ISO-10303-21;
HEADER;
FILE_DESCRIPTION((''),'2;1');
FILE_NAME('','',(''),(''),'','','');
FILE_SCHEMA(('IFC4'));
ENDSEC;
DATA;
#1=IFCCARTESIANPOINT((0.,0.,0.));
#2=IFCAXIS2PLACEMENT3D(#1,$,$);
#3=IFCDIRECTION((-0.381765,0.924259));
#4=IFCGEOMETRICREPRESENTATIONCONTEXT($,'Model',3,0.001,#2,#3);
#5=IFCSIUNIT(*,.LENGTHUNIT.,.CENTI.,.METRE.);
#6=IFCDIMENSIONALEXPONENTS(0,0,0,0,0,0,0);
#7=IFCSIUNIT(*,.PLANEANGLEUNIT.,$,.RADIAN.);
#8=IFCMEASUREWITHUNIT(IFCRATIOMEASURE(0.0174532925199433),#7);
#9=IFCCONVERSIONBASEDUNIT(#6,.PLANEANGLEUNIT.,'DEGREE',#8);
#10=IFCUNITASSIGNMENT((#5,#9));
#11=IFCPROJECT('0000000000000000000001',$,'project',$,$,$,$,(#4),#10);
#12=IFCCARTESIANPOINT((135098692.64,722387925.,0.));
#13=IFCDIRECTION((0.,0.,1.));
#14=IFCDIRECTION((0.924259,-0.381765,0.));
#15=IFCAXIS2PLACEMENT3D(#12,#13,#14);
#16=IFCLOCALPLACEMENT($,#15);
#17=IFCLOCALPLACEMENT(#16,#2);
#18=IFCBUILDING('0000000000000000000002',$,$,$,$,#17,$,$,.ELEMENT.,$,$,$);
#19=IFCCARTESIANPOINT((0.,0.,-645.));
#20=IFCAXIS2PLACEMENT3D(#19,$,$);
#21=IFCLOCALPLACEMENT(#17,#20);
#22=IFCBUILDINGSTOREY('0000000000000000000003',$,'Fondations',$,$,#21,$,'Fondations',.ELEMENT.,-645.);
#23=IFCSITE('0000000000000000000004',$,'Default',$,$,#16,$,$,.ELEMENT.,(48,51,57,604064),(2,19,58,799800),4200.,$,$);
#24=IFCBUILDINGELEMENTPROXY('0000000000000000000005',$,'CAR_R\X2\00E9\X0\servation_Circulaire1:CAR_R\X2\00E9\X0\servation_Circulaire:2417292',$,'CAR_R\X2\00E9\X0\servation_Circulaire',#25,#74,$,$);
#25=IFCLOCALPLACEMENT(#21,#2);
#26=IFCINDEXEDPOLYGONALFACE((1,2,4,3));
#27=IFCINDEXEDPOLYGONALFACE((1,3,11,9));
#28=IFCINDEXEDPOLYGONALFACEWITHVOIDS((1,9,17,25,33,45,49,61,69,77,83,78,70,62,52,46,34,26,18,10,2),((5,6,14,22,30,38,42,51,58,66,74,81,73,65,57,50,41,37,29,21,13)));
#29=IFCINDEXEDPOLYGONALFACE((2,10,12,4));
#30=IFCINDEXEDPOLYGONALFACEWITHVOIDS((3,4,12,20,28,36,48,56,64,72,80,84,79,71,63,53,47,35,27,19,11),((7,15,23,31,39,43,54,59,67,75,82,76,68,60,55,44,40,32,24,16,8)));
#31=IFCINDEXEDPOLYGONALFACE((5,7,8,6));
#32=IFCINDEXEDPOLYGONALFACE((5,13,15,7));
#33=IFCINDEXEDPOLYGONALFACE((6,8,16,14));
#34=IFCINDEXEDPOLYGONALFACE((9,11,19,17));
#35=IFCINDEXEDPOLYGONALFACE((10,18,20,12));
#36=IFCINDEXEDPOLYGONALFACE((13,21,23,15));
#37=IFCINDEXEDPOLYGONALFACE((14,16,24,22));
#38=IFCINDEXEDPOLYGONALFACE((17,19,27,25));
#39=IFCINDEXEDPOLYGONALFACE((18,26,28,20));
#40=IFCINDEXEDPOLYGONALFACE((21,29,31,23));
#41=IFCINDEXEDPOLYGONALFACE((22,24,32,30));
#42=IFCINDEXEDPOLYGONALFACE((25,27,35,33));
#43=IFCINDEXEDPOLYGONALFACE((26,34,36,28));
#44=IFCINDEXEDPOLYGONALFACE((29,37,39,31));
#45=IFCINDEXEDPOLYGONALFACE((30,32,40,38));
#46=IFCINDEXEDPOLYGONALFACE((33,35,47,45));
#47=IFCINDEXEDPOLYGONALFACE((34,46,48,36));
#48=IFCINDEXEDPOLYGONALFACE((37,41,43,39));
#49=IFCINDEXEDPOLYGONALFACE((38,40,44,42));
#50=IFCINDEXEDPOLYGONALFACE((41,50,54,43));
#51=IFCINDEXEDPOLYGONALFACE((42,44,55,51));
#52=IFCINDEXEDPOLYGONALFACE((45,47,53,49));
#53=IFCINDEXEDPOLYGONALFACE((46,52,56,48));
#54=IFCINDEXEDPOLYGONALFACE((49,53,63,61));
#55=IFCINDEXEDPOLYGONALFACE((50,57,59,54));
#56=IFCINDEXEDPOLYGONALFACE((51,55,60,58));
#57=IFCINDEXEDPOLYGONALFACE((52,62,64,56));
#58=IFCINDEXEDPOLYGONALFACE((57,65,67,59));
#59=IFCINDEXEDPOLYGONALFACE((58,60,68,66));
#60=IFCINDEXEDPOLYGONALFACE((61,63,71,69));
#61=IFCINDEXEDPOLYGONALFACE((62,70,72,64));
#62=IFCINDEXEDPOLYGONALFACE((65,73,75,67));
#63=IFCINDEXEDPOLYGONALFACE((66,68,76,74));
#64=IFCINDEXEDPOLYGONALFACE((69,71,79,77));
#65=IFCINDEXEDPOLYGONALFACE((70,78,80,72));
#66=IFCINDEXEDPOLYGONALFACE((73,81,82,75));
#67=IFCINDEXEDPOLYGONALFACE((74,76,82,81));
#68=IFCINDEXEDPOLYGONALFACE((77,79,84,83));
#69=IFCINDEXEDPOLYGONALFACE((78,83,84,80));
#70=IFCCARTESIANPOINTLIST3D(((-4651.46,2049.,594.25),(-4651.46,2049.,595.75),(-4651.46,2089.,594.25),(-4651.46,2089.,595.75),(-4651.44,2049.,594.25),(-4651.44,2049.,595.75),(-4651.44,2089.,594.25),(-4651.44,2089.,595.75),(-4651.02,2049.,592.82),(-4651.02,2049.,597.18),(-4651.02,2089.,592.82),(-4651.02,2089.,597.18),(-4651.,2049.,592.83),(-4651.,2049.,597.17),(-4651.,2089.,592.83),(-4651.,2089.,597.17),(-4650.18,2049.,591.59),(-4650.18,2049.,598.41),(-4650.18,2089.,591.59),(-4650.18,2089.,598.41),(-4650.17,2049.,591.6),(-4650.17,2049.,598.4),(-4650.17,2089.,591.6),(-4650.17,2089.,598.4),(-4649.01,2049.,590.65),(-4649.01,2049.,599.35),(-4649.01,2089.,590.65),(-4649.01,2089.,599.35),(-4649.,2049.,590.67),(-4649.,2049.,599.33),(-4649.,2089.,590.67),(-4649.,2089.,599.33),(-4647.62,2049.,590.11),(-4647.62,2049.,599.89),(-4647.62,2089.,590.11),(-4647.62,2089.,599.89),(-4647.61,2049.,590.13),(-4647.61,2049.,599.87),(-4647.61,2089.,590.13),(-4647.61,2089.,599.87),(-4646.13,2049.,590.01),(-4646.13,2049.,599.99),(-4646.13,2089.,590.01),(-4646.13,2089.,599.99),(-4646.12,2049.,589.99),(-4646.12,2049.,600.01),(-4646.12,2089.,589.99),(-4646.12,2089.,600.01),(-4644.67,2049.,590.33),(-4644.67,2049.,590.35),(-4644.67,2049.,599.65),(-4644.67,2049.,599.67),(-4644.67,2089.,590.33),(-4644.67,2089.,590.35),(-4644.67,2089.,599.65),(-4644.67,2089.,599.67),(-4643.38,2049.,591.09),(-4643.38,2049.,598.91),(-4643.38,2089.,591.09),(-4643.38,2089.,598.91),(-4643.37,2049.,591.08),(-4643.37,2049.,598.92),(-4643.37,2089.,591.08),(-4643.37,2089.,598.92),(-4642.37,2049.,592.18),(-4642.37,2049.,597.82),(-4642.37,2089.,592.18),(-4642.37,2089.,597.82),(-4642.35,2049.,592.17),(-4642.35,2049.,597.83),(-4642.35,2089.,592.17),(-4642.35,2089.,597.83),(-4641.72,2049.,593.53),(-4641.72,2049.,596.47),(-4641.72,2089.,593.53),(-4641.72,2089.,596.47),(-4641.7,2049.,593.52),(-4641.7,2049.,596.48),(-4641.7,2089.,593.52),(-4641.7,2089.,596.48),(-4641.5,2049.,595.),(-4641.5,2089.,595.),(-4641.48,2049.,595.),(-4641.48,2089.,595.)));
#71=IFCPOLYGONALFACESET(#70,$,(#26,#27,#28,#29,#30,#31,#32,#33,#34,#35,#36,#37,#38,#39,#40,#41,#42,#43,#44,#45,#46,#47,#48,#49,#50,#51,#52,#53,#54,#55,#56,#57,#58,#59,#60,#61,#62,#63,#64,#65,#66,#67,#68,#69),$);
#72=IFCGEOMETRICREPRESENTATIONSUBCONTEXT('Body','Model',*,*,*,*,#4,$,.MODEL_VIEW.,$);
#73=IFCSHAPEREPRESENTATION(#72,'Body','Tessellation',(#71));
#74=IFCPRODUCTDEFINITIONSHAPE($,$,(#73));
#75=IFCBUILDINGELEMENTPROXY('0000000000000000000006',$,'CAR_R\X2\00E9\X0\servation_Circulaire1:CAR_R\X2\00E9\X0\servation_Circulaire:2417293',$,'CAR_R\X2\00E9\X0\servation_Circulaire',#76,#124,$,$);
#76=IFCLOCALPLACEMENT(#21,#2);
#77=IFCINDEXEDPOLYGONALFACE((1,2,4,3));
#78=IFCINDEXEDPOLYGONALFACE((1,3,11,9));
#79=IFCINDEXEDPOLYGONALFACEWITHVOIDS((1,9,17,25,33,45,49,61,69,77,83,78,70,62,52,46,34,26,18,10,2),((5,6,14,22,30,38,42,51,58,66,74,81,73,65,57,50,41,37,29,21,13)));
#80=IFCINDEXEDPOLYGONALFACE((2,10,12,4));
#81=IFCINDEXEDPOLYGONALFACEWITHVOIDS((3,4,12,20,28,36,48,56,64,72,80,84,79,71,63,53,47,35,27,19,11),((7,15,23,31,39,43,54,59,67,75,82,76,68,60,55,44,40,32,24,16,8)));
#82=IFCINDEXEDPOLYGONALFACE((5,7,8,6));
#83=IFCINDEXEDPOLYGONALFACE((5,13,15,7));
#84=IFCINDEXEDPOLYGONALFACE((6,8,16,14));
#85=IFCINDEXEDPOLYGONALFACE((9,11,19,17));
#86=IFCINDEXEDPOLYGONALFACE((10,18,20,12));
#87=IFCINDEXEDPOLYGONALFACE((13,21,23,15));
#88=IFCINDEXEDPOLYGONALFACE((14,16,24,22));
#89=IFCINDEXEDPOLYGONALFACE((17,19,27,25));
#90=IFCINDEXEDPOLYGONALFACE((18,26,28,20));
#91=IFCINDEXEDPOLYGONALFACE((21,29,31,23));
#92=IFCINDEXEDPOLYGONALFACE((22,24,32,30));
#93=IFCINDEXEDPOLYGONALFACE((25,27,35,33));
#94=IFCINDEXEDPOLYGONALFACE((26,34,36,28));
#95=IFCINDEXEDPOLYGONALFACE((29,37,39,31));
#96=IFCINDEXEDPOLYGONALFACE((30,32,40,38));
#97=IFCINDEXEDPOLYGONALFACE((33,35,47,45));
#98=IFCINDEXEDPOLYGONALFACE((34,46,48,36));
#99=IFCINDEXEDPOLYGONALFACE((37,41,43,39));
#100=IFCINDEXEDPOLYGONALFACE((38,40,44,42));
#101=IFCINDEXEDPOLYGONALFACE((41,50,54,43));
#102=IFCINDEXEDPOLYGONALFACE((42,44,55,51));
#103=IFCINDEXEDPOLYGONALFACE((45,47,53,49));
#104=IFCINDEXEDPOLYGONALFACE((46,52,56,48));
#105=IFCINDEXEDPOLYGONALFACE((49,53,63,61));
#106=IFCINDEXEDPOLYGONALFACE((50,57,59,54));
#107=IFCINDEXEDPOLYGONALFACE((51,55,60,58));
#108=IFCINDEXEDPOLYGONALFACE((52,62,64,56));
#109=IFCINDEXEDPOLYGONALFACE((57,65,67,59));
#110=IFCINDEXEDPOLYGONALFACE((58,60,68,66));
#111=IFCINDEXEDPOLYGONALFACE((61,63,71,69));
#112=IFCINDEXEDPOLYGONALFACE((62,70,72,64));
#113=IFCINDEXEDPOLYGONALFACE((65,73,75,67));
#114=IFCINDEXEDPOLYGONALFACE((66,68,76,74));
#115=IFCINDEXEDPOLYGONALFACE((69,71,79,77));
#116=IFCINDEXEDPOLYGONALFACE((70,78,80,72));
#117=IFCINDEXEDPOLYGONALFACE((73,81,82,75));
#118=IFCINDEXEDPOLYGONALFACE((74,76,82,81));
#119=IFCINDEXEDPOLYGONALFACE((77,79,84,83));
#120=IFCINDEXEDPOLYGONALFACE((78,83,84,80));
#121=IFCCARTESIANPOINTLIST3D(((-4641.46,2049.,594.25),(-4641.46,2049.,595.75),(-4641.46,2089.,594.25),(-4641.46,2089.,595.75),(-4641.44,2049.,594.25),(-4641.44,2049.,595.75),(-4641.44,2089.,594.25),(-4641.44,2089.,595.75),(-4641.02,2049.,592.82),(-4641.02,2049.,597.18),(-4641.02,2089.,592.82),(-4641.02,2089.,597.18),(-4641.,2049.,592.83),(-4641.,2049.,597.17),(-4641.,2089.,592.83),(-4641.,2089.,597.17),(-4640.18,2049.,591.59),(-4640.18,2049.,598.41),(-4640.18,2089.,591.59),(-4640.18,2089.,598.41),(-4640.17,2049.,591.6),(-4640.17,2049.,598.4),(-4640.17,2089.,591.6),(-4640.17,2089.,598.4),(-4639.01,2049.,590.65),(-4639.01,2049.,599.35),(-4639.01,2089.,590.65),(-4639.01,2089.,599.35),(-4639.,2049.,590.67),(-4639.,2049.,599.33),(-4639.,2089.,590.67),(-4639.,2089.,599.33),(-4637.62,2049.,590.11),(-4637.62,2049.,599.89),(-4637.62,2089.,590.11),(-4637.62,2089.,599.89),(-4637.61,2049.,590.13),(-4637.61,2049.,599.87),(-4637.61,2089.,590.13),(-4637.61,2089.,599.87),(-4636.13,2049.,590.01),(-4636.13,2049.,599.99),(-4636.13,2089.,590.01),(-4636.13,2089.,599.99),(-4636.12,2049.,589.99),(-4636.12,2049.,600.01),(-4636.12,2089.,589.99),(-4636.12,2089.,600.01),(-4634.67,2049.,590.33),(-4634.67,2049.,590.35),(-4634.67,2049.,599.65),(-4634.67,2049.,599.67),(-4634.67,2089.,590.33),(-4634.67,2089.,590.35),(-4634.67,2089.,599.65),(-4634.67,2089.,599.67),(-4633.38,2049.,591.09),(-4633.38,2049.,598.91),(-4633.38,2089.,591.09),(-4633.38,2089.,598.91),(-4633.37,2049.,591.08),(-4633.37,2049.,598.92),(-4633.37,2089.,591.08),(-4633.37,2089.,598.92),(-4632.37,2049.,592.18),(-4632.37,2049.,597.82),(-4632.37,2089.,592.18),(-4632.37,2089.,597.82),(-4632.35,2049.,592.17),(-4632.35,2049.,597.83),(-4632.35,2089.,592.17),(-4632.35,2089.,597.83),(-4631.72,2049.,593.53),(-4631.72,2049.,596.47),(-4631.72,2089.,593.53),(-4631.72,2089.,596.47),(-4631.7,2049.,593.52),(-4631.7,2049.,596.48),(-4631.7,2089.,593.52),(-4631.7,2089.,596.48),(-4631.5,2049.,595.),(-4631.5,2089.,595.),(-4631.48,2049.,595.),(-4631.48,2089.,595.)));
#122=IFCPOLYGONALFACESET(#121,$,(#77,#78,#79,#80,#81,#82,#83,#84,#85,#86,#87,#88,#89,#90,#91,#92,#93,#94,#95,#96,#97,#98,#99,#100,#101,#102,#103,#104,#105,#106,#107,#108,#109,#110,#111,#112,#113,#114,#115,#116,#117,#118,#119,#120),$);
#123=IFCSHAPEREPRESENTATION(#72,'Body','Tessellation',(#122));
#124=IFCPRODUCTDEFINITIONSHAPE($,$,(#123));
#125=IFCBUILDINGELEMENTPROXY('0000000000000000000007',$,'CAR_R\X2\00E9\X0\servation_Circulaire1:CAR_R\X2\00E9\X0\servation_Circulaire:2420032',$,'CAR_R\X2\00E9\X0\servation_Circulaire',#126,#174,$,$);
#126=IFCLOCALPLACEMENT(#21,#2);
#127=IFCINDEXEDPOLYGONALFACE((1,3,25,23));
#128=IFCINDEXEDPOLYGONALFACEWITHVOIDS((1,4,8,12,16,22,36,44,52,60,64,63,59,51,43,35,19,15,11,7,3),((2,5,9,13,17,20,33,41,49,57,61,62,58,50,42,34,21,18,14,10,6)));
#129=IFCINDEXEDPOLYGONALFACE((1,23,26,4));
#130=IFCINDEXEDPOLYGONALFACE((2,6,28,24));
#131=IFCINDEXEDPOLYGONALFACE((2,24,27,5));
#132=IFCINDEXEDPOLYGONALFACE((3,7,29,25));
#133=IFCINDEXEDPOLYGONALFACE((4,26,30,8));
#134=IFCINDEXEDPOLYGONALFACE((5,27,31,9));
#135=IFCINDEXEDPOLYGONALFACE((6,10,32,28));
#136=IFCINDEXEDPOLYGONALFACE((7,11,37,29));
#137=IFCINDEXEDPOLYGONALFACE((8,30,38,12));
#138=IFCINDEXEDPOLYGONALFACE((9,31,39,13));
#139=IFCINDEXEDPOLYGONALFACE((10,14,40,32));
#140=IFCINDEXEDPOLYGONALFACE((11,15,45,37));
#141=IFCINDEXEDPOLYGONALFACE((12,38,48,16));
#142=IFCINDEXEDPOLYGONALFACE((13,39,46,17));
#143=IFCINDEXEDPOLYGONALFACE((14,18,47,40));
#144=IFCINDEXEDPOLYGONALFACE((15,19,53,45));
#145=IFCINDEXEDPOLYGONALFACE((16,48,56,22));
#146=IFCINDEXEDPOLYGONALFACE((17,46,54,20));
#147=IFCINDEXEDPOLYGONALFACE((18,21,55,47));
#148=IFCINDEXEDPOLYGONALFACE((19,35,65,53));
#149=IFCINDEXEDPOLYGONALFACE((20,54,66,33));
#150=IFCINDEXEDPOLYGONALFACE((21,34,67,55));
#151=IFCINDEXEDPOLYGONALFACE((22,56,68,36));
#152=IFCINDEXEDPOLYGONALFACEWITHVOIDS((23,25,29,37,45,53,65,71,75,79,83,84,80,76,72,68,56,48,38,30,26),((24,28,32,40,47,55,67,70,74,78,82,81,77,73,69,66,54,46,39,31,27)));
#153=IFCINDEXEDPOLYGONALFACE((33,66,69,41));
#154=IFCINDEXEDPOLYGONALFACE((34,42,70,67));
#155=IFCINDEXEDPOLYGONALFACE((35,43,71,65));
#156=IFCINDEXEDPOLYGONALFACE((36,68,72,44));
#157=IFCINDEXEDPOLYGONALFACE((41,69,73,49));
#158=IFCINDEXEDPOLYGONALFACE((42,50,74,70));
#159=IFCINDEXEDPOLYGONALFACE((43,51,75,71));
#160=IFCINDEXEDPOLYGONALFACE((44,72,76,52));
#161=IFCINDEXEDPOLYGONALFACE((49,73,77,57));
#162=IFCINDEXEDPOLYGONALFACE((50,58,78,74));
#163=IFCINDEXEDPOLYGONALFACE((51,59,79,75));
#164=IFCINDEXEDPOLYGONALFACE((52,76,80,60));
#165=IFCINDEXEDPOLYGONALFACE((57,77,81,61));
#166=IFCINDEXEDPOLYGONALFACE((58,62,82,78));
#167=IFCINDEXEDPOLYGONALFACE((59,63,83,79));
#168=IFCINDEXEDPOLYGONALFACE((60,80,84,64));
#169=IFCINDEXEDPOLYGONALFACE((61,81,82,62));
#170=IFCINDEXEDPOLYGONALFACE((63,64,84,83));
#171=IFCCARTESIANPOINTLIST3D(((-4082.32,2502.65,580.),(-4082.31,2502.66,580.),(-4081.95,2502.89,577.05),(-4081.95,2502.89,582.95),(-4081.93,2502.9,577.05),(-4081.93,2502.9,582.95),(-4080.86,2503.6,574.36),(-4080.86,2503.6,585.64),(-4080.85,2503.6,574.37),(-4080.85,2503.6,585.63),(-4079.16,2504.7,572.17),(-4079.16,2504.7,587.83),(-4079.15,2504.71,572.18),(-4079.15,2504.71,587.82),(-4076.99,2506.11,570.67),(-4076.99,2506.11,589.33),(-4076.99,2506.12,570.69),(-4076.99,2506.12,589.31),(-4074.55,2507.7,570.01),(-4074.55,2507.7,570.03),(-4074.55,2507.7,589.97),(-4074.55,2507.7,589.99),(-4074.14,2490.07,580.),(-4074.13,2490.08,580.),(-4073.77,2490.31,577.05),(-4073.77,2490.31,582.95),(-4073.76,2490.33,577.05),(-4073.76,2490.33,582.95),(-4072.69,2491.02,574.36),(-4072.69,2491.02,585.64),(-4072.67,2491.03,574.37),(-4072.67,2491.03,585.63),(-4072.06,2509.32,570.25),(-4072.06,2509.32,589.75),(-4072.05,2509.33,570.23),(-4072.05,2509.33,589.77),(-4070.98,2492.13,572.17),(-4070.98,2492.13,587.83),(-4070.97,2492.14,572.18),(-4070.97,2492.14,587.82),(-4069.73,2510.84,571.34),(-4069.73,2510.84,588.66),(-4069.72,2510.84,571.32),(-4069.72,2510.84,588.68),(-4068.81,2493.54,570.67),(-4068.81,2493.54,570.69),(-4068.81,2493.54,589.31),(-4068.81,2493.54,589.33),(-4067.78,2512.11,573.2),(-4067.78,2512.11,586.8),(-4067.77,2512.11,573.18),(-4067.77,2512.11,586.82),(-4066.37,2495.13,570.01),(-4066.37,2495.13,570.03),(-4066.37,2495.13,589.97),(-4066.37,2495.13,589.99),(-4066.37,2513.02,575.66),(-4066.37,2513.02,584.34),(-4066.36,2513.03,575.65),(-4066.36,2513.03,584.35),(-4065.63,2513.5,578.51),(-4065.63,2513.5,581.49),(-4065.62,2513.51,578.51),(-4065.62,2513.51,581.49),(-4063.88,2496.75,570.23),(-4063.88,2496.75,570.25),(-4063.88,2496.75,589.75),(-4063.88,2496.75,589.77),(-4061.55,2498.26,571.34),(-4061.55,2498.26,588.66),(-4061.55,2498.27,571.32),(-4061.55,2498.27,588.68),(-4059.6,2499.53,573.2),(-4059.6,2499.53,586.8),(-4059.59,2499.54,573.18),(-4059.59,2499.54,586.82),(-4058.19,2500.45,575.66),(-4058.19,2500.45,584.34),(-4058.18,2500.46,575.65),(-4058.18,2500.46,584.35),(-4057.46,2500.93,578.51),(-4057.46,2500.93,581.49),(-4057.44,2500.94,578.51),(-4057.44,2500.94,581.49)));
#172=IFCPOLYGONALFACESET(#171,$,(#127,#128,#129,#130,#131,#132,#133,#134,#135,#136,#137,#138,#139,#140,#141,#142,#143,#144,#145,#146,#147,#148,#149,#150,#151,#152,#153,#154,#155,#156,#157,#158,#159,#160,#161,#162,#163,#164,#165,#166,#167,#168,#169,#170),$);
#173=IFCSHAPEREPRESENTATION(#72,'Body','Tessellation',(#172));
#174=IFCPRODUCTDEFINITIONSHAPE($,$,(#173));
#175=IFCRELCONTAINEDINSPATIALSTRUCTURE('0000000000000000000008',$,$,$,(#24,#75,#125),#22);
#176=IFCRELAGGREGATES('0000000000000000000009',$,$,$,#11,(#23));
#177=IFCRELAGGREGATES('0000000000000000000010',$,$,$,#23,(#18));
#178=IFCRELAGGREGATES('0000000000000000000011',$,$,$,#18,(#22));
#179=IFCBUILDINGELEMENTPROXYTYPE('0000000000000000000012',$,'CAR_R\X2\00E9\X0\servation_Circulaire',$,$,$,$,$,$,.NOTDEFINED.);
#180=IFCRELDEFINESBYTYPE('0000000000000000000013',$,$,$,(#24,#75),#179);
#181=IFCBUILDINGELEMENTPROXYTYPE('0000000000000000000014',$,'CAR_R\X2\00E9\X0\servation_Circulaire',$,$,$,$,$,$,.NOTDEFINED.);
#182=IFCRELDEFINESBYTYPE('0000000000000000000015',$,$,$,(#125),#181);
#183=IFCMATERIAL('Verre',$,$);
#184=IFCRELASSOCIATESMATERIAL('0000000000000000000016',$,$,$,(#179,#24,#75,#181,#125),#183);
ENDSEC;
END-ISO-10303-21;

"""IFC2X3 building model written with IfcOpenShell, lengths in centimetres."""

from ifc_helpers import new_model, entity, si_unit, converted_unit, direction, frame, frame_2d, origin, place, context, subcontext, project, spatial, hollow_circle, extrude, source, transform, mapped, material, type_object, type_shapes, element, save


model = new_model("IFC2X3")

# Units and contexts
model_context = context("Model", 3, precision=0.001, world=origin(), true_north=direction((-0.381765, 0.924259)))
body_context = subcontext(model_context, "Body", "Model", "MODEL_VIEW")
ifc_project = project(units=[si_unit("LENGTHUNIT", "METRE", prefix="CENTI"), converted_unit("PLANEANGLEUNIT", "DEGREE", entity("IfcRatioMeasure", 0.0174532925199433), si_unit("PLANEANGLEUNIT", "RADIAN"), dimensions=[0, 0, 0, 0, 0, 0, 0])], contexts=[model_context])

# Site, building, storey
site_placement = place(None, frame((135098692.64, 722387925.0, 0.0), z_axis=(0.0, 0.0, 1.0), x_axis=(0.924259, -0.381765, 0.0)))
site = spatial("IfcSite", under=ifc_project, at=site_placement, Name="Default", CompositionType="ELEMENT", RefLatitude=(48, 51, 57, 604064), RefLongitude=(2, 19, 58, 799800), RefElevation=4200.0)
building_placement = place(site_placement, origin())
building = spatial("IfcBuilding", under=site, at=building_placement, CompositionType="ELEMENT")
storey_placement = place(building_placement, frame((0.0, 0.0, -645.0)))
storey = spatial("IfcBuildingStorey", under=building, at=storey_placement, Name="Fondations", LongName="Fondations", CompositionType="ELEMENT", Elevation=-645.0)

# Building element proxies
ifc_material_1 = material(Name="Verre")
building_element_proxy_type_1 = type_object("IfcBuildingElementProxyType", Name="CAR_Réservation_Circulaire", PredefinedType="NOTDEFINED", material=ifc_material_1)
shared_shape_1 = source(origin(), body_context, "Body", "SweptSolid", [
    extrude(hollow_circle(Radius=5.02, WallThickness=0.02, at=frame_2d((0.0, 0.0), x_axis=(1.0, 0.0))), frame((0.0, 0.0, -40.0)), (0.0, 0.0, 1.0), 40.0),
])
type_shapes(building_element_proxy_type_1, [shared_shape_1])
for number, where, z_axis, x_axis, name in (
    (1, (-4646.5, 2049.0, 595.0), (0.0, -1.0, 0.0), (1.0, 0.0, 0.0), "CAR_Réservation_Circulaire1:CAR_Réservation_Circulaire:2417292"),
    (2, (-4636.5, 2049.0, 595.0), (0.0, -1.0, 0.0), (1.0, 0.0, 0.0), "CAR_Réservation_Circulaire1:CAR_Réservation_Circulaire:2417293"),
):
    element("IfcBuildingElementProxy", number, at=place(storey_placement, frame(where, z_axis=z_axis, x_axis=x_axis)), inside=storey, type_object=building_element_proxy_type_1, material=ifc_material_1, Name=name, ObjectType="CAR_Réservation_Circulaire", context=body_context, shape_type="MappedRepresentation", body=[
        mapped(shared_shape_1, transform((0.0, 0.0, 0.0), scale=1.0)),
    ])
building_element_proxy_type_2 = type_object("IfcBuildingElementProxyType", Name="CAR_Réservation_Circulaire", PredefinedType="NOTDEFINED", material=ifc_material_1)
shared_shape_2 = source(origin(), body_context, "Body", "SweptSolid", [
    extrude(hollow_circle(Radius=10.02, WallThickness=0.02, at=frame_2d((0.0, 0.0), x_axis=(1.0, 0.0))), frame((0.0, 0.0, -15.0)), (0.0, 0.0, 1.0), 15.0),
])
type_shapes(building_element_proxy_type_2, [shared_shape_2])
for number, where, z_axis, x_axis, name in (
    (3, (-4073.92, 2508.11, 580.0), (-0.545236, 0.838282, 0.0), (-0.838282, -0.545236, 0.0), "CAR_Réservation_Circulaire1:CAR_Réservation_Circulaire:2420032"),
):
    element("IfcBuildingElementProxy", number, at=place(storey_placement, frame(where, z_axis=z_axis, x_axis=x_axis)), inside=storey, type_object=building_element_proxy_type_2, material=ifc_material_1, Name=name, ObjectType="CAR_Réservation_Circulaire", context=body_context, shape_type="MappedRepresentation", body=[
        mapped(shared_shape_2, transform((0.0, 0.0, 0.0), scale=1.0)),
    ])

save(model, "model.ifc")
